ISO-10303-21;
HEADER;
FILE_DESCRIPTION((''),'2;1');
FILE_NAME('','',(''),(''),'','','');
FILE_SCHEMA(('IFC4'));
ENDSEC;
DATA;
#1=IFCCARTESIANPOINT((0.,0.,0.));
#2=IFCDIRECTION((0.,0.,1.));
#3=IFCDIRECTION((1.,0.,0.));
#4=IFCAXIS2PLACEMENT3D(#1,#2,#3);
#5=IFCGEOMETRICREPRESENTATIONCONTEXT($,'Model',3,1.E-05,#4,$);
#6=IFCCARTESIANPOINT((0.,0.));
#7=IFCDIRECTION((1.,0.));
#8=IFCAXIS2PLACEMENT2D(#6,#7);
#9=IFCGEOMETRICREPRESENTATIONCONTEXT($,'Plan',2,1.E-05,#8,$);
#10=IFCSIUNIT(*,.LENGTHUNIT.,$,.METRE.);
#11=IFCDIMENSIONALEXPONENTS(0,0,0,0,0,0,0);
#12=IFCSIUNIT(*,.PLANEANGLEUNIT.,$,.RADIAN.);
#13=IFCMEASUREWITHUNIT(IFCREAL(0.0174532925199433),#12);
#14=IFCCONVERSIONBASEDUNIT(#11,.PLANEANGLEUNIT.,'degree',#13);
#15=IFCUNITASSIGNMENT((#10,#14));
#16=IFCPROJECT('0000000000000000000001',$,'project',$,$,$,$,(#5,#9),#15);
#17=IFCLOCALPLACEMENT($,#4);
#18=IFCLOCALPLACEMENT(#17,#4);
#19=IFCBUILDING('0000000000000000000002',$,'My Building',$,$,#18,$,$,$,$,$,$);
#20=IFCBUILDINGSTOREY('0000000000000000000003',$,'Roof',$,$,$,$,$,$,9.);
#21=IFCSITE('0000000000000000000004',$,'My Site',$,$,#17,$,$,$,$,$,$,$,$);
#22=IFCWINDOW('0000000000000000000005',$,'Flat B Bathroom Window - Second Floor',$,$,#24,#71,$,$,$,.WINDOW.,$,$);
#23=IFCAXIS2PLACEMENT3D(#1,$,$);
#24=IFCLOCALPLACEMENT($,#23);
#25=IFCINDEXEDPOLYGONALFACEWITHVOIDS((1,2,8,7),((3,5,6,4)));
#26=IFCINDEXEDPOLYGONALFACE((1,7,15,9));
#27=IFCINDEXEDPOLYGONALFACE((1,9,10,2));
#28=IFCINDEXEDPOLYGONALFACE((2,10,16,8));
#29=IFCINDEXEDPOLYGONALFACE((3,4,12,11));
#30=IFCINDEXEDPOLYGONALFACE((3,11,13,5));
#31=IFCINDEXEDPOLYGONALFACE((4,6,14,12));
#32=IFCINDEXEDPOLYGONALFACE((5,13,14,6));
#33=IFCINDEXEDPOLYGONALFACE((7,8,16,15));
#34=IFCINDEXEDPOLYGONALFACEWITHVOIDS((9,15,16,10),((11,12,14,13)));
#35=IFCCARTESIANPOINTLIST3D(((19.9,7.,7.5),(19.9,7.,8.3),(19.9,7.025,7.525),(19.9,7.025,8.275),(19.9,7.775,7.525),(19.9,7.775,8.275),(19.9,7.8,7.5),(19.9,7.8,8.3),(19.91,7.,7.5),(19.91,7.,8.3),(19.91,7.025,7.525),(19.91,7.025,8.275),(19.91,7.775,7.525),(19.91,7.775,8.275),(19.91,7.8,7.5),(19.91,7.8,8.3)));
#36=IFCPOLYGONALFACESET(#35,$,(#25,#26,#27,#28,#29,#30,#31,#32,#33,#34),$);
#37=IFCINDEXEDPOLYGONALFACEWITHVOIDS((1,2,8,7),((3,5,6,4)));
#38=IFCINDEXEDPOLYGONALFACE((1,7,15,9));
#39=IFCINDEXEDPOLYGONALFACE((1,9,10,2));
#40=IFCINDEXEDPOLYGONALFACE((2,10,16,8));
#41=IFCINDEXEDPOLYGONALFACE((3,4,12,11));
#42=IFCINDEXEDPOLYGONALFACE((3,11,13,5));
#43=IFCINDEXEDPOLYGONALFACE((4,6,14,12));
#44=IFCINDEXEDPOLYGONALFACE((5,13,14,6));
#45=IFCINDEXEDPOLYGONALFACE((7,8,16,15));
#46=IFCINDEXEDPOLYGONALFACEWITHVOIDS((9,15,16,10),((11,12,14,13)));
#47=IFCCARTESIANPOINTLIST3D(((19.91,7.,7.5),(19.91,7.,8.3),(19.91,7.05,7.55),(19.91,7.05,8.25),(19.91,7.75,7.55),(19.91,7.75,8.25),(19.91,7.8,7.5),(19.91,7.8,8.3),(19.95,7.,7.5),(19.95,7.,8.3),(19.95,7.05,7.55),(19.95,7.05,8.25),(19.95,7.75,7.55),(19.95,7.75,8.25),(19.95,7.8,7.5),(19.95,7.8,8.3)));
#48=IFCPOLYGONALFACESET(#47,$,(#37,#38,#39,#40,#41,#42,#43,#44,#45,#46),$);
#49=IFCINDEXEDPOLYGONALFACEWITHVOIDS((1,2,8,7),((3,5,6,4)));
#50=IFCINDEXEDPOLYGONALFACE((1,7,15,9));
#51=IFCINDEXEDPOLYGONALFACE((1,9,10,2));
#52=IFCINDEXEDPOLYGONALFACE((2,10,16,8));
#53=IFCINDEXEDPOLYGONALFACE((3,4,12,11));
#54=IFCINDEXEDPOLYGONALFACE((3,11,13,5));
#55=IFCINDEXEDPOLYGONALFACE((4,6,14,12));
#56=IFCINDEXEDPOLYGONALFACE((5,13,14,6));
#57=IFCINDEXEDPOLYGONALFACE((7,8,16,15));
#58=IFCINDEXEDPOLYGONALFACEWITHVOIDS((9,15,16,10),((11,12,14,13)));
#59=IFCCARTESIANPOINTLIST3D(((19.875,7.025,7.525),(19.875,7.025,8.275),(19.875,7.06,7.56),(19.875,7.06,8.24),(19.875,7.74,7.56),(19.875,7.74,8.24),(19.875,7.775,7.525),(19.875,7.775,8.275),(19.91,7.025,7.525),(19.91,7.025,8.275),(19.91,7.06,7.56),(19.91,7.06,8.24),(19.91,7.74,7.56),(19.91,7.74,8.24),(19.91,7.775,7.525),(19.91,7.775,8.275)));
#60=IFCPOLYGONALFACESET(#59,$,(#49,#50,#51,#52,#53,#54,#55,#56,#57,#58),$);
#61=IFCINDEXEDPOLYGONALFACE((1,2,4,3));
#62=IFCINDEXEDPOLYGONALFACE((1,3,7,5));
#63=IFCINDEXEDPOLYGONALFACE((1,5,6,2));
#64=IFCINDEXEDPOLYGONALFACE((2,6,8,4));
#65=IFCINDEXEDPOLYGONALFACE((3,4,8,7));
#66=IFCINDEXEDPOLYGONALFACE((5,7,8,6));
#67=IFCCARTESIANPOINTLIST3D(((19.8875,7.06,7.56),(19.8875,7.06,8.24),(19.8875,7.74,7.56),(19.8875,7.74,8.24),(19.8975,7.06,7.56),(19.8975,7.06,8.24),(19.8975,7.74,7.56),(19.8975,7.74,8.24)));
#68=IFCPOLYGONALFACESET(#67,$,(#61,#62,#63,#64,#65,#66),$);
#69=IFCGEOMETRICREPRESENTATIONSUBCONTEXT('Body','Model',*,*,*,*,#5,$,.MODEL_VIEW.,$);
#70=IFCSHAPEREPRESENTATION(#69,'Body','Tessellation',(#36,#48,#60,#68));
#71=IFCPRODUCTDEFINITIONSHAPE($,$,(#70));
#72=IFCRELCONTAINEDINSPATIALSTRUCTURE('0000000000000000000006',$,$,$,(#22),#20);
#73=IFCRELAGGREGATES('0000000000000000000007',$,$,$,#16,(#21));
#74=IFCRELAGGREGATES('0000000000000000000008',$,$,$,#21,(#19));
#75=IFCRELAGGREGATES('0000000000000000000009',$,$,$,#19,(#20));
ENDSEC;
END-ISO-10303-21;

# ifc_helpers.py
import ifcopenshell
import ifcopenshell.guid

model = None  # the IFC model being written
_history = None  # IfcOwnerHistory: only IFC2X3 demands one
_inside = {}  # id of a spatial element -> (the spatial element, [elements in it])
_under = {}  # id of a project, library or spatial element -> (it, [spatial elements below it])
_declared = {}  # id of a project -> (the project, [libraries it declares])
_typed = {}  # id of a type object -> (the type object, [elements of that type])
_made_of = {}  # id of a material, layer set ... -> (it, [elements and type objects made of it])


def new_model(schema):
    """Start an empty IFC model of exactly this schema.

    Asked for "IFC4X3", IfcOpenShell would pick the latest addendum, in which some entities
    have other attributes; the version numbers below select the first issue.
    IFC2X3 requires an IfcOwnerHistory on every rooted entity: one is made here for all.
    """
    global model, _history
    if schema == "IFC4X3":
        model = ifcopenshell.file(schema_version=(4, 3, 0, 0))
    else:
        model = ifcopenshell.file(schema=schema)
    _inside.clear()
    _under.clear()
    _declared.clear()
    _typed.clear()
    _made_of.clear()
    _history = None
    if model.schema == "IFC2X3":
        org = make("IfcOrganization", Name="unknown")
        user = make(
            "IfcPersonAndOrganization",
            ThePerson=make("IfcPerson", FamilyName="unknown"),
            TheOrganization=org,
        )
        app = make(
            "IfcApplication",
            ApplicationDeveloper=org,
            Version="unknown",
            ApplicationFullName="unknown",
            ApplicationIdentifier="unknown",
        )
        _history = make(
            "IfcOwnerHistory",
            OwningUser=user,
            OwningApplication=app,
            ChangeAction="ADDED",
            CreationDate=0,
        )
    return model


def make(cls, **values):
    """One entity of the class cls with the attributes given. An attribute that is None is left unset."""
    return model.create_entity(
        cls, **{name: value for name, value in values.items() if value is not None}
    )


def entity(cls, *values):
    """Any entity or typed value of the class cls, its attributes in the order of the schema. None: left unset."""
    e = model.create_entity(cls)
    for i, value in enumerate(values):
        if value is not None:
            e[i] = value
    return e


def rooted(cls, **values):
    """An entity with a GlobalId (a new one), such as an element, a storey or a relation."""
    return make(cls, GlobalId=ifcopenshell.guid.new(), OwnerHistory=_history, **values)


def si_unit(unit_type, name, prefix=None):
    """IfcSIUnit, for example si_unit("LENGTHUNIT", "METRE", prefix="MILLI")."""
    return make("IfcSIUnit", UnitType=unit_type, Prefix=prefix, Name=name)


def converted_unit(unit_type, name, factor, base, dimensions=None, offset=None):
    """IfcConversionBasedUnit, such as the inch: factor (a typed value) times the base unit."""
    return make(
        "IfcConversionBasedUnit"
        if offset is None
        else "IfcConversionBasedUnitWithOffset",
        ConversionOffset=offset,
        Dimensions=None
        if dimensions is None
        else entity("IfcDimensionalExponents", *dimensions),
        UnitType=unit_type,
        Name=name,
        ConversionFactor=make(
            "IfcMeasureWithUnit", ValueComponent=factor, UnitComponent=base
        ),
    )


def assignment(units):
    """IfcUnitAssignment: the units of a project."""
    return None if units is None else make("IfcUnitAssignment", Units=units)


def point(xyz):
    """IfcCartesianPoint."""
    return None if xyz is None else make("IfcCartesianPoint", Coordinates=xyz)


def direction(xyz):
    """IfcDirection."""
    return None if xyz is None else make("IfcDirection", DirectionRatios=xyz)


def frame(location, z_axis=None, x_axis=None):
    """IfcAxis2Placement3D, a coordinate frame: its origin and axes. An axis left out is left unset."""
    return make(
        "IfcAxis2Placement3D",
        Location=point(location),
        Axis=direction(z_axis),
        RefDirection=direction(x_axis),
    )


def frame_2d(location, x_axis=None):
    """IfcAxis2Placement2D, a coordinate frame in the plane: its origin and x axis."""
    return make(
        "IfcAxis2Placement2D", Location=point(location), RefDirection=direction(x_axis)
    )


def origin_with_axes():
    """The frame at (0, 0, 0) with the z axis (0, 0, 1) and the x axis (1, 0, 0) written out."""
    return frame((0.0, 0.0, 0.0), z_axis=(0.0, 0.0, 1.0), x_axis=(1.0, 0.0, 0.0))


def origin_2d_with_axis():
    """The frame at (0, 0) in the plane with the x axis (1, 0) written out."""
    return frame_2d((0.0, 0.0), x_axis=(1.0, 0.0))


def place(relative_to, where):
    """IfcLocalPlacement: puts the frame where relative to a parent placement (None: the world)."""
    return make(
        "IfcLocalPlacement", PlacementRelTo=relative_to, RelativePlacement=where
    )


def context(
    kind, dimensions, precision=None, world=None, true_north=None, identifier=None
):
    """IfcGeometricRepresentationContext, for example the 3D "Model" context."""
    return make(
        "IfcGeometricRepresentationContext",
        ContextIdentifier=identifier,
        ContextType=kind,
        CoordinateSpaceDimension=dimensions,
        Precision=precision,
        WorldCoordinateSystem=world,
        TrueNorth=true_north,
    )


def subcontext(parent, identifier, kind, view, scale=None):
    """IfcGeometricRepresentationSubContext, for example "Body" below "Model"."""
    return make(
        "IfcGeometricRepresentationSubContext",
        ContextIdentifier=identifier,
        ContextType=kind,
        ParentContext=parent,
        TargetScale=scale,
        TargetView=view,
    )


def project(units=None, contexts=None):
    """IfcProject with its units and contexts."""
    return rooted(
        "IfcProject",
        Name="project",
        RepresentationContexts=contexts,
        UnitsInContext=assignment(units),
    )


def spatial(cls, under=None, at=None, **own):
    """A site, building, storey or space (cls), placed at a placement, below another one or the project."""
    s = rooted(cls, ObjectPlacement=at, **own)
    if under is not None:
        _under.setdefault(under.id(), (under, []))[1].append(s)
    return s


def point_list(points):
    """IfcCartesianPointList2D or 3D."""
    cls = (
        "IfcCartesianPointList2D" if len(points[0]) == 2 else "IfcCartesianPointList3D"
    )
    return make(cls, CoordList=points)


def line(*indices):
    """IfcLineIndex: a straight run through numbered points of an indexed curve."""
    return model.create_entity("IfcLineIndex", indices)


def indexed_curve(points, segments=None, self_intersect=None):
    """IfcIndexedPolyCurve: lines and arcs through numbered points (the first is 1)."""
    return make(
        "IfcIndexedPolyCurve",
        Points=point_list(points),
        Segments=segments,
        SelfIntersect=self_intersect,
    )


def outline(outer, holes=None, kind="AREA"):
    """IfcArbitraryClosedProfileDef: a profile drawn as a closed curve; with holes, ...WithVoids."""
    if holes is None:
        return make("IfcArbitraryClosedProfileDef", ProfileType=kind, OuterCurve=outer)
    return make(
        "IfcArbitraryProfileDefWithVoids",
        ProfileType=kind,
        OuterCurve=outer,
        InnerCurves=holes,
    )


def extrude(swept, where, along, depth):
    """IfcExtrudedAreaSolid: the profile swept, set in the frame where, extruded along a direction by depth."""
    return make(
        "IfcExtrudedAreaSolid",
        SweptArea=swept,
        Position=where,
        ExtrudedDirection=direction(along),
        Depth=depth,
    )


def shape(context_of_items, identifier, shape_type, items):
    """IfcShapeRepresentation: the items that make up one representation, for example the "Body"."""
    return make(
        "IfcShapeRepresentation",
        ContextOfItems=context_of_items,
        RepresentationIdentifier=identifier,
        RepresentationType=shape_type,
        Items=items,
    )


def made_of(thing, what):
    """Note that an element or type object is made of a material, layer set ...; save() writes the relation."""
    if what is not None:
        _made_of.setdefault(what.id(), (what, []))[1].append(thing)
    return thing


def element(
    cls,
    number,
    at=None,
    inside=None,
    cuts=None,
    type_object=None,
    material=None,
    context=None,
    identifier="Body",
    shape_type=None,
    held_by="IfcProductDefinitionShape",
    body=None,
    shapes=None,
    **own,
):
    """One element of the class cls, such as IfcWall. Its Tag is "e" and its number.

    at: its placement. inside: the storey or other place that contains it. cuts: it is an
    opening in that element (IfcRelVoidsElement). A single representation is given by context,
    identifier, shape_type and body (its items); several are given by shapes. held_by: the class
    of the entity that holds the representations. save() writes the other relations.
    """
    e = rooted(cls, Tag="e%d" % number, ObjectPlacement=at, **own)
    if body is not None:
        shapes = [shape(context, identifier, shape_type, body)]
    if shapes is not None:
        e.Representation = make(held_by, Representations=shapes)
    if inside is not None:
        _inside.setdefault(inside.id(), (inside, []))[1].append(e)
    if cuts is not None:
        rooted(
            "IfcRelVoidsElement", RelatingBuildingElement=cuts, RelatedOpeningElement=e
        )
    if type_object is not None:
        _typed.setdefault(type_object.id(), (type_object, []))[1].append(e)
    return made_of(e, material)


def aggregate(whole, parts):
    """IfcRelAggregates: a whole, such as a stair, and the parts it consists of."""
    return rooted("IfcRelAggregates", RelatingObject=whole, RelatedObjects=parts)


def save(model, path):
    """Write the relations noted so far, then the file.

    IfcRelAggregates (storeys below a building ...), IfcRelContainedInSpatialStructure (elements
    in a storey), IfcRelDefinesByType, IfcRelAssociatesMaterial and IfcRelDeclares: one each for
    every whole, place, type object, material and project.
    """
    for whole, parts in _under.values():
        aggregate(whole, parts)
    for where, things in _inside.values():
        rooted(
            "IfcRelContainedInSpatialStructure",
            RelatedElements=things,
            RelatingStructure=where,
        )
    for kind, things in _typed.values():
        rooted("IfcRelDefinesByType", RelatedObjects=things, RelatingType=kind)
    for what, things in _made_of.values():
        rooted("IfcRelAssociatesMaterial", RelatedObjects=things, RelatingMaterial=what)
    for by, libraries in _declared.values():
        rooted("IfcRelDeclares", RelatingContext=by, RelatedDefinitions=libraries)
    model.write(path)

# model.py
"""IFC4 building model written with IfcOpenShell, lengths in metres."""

from ifc_helpers import new_model, entity, si_unit, converted_unit, frame, origin_with_axes, origin_2d_with_axis, place, context, subcontext, project, spatial, line, indexed_curve, outline, extrude, element, save


model = new_model("IFC4")

# Units and contexts
model_context = context("Model", 3, precision=1e-05, world=origin_with_axes())
plan_context = context("Plan", 2, precision=1e-05, world=origin_2d_with_axis())
body_context = subcontext(model_context, "Body", "Model", "MODEL_VIEW")
ifc_project = project(units=[si_unit("LENGTHUNIT", "METRE"), converted_unit("PLANEANGLEUNIT", "degree", entity("IfcReal", 0.0174532925199433), si_unit("PLANEANGLEUNIT", "RADIAN"), dimensions=[0, 0, 0, 0, 0, 0, 0])], contexts=[model_context, plan_context])

# Site, building, storey
site_placement = place(None, origin_with_axes())
site = spatial("IfcSite", under=ifc_project, at=site_placement, Name="My Site")
building_placement = place(site_placement, origin_with_axes())
building = spatial("IfcBuilding", under=site, at=building_placement, Name="My Building")
storey = spatial("IfcBuildingStorey", under=building, Name="Roof", Elevation=9.0)

# Window
window_1_placement = place(None, frame((20.0, 7.0, 7.5), z_axis=(0.0, 0.0, 1.0), x_axis=(0.0, 1.0, 0.0)))
element("IfcWindow", 1, at=window_1_placement, inside=storey, Name="Flat B Bathroom Window - Second Floor", PredefinedType="WINDOW", context=body_context, shape_type="SweptSolid", body=[
    extrude(outline(indexed_curve([(0.0, 0.0), (0.8, 0.0), (0.8, 0.8), (0.0, 0.8)], segments=[line(1, 2, 3, 4, 1)]), holes=[indexed_curve([(0.025, 0.025), (0.775, 0.025), (0.775, 0.775), (0.025, 0.775)], segments=[line(1, 2, 3, 4, 1)])]), frame((0.0, 0.09, 0.0), z_axis=(0.0, -1.0, 0.0), x_axis=(1.0, 0.0, 0.0)), (0.0, 0.0, -1.0), 0.01),
    extrude(outline(indexed_curve([(0.0, 0.0), (0.8, 0.0), (0.8, 0.8), (0.0, 0.8)], segments=[line(1, 2, 3, 4, 1)]), holes=[indexed_curve([(0.05, 0.05), (0.75, 0.05), (0.75, 0.75), (0.05, 0.75)], segments=[line(1, 2, 3, 4, 1)])]), frame((0.0, 0.05, 0.0), z_axis=(0.0, -1.0, 0.0), x_axis=(1.0, 0.0, 0.0)), (0.0, 0.0, -1.0), 0.04),
    extrude(outline(indexed_curve([(0.0, 0.0), (0.75, 0.0), (0.75, 0.75), (0.0, 0.75)], segments=[line(1, 2, 3, 4, 1)]), holes=[indexed_curve([(0.035, 0.035), (0.715, 0.035), (0.715, 0.715), (0.035, 0.715)], segments=[line(1, 2, 3, 4, 1)])]), frame((0.025, 0.09, 0.025), z_axis=(0.0, -1.0, 0.0), x_axis=(1.0, 0.0, 0.0)), (0.0, 0.0, -1.0), 0.035),
    extrude(outline(indexed_curve([(0.035, 0.035), (0.715, 0.035), (0.715, 0.715), (0.035, 0.715)], segments=[line(1, 2, 3, 4, 1)])), frame((0.025, 0.1025, 0.025), z_axis=(0.0, -1.0, 0.0), x_axis=(1.0, 0.0, 0.0)), (0.0, 0.0, -1.0), 0.01),
])

save(model, "model.ifc")
